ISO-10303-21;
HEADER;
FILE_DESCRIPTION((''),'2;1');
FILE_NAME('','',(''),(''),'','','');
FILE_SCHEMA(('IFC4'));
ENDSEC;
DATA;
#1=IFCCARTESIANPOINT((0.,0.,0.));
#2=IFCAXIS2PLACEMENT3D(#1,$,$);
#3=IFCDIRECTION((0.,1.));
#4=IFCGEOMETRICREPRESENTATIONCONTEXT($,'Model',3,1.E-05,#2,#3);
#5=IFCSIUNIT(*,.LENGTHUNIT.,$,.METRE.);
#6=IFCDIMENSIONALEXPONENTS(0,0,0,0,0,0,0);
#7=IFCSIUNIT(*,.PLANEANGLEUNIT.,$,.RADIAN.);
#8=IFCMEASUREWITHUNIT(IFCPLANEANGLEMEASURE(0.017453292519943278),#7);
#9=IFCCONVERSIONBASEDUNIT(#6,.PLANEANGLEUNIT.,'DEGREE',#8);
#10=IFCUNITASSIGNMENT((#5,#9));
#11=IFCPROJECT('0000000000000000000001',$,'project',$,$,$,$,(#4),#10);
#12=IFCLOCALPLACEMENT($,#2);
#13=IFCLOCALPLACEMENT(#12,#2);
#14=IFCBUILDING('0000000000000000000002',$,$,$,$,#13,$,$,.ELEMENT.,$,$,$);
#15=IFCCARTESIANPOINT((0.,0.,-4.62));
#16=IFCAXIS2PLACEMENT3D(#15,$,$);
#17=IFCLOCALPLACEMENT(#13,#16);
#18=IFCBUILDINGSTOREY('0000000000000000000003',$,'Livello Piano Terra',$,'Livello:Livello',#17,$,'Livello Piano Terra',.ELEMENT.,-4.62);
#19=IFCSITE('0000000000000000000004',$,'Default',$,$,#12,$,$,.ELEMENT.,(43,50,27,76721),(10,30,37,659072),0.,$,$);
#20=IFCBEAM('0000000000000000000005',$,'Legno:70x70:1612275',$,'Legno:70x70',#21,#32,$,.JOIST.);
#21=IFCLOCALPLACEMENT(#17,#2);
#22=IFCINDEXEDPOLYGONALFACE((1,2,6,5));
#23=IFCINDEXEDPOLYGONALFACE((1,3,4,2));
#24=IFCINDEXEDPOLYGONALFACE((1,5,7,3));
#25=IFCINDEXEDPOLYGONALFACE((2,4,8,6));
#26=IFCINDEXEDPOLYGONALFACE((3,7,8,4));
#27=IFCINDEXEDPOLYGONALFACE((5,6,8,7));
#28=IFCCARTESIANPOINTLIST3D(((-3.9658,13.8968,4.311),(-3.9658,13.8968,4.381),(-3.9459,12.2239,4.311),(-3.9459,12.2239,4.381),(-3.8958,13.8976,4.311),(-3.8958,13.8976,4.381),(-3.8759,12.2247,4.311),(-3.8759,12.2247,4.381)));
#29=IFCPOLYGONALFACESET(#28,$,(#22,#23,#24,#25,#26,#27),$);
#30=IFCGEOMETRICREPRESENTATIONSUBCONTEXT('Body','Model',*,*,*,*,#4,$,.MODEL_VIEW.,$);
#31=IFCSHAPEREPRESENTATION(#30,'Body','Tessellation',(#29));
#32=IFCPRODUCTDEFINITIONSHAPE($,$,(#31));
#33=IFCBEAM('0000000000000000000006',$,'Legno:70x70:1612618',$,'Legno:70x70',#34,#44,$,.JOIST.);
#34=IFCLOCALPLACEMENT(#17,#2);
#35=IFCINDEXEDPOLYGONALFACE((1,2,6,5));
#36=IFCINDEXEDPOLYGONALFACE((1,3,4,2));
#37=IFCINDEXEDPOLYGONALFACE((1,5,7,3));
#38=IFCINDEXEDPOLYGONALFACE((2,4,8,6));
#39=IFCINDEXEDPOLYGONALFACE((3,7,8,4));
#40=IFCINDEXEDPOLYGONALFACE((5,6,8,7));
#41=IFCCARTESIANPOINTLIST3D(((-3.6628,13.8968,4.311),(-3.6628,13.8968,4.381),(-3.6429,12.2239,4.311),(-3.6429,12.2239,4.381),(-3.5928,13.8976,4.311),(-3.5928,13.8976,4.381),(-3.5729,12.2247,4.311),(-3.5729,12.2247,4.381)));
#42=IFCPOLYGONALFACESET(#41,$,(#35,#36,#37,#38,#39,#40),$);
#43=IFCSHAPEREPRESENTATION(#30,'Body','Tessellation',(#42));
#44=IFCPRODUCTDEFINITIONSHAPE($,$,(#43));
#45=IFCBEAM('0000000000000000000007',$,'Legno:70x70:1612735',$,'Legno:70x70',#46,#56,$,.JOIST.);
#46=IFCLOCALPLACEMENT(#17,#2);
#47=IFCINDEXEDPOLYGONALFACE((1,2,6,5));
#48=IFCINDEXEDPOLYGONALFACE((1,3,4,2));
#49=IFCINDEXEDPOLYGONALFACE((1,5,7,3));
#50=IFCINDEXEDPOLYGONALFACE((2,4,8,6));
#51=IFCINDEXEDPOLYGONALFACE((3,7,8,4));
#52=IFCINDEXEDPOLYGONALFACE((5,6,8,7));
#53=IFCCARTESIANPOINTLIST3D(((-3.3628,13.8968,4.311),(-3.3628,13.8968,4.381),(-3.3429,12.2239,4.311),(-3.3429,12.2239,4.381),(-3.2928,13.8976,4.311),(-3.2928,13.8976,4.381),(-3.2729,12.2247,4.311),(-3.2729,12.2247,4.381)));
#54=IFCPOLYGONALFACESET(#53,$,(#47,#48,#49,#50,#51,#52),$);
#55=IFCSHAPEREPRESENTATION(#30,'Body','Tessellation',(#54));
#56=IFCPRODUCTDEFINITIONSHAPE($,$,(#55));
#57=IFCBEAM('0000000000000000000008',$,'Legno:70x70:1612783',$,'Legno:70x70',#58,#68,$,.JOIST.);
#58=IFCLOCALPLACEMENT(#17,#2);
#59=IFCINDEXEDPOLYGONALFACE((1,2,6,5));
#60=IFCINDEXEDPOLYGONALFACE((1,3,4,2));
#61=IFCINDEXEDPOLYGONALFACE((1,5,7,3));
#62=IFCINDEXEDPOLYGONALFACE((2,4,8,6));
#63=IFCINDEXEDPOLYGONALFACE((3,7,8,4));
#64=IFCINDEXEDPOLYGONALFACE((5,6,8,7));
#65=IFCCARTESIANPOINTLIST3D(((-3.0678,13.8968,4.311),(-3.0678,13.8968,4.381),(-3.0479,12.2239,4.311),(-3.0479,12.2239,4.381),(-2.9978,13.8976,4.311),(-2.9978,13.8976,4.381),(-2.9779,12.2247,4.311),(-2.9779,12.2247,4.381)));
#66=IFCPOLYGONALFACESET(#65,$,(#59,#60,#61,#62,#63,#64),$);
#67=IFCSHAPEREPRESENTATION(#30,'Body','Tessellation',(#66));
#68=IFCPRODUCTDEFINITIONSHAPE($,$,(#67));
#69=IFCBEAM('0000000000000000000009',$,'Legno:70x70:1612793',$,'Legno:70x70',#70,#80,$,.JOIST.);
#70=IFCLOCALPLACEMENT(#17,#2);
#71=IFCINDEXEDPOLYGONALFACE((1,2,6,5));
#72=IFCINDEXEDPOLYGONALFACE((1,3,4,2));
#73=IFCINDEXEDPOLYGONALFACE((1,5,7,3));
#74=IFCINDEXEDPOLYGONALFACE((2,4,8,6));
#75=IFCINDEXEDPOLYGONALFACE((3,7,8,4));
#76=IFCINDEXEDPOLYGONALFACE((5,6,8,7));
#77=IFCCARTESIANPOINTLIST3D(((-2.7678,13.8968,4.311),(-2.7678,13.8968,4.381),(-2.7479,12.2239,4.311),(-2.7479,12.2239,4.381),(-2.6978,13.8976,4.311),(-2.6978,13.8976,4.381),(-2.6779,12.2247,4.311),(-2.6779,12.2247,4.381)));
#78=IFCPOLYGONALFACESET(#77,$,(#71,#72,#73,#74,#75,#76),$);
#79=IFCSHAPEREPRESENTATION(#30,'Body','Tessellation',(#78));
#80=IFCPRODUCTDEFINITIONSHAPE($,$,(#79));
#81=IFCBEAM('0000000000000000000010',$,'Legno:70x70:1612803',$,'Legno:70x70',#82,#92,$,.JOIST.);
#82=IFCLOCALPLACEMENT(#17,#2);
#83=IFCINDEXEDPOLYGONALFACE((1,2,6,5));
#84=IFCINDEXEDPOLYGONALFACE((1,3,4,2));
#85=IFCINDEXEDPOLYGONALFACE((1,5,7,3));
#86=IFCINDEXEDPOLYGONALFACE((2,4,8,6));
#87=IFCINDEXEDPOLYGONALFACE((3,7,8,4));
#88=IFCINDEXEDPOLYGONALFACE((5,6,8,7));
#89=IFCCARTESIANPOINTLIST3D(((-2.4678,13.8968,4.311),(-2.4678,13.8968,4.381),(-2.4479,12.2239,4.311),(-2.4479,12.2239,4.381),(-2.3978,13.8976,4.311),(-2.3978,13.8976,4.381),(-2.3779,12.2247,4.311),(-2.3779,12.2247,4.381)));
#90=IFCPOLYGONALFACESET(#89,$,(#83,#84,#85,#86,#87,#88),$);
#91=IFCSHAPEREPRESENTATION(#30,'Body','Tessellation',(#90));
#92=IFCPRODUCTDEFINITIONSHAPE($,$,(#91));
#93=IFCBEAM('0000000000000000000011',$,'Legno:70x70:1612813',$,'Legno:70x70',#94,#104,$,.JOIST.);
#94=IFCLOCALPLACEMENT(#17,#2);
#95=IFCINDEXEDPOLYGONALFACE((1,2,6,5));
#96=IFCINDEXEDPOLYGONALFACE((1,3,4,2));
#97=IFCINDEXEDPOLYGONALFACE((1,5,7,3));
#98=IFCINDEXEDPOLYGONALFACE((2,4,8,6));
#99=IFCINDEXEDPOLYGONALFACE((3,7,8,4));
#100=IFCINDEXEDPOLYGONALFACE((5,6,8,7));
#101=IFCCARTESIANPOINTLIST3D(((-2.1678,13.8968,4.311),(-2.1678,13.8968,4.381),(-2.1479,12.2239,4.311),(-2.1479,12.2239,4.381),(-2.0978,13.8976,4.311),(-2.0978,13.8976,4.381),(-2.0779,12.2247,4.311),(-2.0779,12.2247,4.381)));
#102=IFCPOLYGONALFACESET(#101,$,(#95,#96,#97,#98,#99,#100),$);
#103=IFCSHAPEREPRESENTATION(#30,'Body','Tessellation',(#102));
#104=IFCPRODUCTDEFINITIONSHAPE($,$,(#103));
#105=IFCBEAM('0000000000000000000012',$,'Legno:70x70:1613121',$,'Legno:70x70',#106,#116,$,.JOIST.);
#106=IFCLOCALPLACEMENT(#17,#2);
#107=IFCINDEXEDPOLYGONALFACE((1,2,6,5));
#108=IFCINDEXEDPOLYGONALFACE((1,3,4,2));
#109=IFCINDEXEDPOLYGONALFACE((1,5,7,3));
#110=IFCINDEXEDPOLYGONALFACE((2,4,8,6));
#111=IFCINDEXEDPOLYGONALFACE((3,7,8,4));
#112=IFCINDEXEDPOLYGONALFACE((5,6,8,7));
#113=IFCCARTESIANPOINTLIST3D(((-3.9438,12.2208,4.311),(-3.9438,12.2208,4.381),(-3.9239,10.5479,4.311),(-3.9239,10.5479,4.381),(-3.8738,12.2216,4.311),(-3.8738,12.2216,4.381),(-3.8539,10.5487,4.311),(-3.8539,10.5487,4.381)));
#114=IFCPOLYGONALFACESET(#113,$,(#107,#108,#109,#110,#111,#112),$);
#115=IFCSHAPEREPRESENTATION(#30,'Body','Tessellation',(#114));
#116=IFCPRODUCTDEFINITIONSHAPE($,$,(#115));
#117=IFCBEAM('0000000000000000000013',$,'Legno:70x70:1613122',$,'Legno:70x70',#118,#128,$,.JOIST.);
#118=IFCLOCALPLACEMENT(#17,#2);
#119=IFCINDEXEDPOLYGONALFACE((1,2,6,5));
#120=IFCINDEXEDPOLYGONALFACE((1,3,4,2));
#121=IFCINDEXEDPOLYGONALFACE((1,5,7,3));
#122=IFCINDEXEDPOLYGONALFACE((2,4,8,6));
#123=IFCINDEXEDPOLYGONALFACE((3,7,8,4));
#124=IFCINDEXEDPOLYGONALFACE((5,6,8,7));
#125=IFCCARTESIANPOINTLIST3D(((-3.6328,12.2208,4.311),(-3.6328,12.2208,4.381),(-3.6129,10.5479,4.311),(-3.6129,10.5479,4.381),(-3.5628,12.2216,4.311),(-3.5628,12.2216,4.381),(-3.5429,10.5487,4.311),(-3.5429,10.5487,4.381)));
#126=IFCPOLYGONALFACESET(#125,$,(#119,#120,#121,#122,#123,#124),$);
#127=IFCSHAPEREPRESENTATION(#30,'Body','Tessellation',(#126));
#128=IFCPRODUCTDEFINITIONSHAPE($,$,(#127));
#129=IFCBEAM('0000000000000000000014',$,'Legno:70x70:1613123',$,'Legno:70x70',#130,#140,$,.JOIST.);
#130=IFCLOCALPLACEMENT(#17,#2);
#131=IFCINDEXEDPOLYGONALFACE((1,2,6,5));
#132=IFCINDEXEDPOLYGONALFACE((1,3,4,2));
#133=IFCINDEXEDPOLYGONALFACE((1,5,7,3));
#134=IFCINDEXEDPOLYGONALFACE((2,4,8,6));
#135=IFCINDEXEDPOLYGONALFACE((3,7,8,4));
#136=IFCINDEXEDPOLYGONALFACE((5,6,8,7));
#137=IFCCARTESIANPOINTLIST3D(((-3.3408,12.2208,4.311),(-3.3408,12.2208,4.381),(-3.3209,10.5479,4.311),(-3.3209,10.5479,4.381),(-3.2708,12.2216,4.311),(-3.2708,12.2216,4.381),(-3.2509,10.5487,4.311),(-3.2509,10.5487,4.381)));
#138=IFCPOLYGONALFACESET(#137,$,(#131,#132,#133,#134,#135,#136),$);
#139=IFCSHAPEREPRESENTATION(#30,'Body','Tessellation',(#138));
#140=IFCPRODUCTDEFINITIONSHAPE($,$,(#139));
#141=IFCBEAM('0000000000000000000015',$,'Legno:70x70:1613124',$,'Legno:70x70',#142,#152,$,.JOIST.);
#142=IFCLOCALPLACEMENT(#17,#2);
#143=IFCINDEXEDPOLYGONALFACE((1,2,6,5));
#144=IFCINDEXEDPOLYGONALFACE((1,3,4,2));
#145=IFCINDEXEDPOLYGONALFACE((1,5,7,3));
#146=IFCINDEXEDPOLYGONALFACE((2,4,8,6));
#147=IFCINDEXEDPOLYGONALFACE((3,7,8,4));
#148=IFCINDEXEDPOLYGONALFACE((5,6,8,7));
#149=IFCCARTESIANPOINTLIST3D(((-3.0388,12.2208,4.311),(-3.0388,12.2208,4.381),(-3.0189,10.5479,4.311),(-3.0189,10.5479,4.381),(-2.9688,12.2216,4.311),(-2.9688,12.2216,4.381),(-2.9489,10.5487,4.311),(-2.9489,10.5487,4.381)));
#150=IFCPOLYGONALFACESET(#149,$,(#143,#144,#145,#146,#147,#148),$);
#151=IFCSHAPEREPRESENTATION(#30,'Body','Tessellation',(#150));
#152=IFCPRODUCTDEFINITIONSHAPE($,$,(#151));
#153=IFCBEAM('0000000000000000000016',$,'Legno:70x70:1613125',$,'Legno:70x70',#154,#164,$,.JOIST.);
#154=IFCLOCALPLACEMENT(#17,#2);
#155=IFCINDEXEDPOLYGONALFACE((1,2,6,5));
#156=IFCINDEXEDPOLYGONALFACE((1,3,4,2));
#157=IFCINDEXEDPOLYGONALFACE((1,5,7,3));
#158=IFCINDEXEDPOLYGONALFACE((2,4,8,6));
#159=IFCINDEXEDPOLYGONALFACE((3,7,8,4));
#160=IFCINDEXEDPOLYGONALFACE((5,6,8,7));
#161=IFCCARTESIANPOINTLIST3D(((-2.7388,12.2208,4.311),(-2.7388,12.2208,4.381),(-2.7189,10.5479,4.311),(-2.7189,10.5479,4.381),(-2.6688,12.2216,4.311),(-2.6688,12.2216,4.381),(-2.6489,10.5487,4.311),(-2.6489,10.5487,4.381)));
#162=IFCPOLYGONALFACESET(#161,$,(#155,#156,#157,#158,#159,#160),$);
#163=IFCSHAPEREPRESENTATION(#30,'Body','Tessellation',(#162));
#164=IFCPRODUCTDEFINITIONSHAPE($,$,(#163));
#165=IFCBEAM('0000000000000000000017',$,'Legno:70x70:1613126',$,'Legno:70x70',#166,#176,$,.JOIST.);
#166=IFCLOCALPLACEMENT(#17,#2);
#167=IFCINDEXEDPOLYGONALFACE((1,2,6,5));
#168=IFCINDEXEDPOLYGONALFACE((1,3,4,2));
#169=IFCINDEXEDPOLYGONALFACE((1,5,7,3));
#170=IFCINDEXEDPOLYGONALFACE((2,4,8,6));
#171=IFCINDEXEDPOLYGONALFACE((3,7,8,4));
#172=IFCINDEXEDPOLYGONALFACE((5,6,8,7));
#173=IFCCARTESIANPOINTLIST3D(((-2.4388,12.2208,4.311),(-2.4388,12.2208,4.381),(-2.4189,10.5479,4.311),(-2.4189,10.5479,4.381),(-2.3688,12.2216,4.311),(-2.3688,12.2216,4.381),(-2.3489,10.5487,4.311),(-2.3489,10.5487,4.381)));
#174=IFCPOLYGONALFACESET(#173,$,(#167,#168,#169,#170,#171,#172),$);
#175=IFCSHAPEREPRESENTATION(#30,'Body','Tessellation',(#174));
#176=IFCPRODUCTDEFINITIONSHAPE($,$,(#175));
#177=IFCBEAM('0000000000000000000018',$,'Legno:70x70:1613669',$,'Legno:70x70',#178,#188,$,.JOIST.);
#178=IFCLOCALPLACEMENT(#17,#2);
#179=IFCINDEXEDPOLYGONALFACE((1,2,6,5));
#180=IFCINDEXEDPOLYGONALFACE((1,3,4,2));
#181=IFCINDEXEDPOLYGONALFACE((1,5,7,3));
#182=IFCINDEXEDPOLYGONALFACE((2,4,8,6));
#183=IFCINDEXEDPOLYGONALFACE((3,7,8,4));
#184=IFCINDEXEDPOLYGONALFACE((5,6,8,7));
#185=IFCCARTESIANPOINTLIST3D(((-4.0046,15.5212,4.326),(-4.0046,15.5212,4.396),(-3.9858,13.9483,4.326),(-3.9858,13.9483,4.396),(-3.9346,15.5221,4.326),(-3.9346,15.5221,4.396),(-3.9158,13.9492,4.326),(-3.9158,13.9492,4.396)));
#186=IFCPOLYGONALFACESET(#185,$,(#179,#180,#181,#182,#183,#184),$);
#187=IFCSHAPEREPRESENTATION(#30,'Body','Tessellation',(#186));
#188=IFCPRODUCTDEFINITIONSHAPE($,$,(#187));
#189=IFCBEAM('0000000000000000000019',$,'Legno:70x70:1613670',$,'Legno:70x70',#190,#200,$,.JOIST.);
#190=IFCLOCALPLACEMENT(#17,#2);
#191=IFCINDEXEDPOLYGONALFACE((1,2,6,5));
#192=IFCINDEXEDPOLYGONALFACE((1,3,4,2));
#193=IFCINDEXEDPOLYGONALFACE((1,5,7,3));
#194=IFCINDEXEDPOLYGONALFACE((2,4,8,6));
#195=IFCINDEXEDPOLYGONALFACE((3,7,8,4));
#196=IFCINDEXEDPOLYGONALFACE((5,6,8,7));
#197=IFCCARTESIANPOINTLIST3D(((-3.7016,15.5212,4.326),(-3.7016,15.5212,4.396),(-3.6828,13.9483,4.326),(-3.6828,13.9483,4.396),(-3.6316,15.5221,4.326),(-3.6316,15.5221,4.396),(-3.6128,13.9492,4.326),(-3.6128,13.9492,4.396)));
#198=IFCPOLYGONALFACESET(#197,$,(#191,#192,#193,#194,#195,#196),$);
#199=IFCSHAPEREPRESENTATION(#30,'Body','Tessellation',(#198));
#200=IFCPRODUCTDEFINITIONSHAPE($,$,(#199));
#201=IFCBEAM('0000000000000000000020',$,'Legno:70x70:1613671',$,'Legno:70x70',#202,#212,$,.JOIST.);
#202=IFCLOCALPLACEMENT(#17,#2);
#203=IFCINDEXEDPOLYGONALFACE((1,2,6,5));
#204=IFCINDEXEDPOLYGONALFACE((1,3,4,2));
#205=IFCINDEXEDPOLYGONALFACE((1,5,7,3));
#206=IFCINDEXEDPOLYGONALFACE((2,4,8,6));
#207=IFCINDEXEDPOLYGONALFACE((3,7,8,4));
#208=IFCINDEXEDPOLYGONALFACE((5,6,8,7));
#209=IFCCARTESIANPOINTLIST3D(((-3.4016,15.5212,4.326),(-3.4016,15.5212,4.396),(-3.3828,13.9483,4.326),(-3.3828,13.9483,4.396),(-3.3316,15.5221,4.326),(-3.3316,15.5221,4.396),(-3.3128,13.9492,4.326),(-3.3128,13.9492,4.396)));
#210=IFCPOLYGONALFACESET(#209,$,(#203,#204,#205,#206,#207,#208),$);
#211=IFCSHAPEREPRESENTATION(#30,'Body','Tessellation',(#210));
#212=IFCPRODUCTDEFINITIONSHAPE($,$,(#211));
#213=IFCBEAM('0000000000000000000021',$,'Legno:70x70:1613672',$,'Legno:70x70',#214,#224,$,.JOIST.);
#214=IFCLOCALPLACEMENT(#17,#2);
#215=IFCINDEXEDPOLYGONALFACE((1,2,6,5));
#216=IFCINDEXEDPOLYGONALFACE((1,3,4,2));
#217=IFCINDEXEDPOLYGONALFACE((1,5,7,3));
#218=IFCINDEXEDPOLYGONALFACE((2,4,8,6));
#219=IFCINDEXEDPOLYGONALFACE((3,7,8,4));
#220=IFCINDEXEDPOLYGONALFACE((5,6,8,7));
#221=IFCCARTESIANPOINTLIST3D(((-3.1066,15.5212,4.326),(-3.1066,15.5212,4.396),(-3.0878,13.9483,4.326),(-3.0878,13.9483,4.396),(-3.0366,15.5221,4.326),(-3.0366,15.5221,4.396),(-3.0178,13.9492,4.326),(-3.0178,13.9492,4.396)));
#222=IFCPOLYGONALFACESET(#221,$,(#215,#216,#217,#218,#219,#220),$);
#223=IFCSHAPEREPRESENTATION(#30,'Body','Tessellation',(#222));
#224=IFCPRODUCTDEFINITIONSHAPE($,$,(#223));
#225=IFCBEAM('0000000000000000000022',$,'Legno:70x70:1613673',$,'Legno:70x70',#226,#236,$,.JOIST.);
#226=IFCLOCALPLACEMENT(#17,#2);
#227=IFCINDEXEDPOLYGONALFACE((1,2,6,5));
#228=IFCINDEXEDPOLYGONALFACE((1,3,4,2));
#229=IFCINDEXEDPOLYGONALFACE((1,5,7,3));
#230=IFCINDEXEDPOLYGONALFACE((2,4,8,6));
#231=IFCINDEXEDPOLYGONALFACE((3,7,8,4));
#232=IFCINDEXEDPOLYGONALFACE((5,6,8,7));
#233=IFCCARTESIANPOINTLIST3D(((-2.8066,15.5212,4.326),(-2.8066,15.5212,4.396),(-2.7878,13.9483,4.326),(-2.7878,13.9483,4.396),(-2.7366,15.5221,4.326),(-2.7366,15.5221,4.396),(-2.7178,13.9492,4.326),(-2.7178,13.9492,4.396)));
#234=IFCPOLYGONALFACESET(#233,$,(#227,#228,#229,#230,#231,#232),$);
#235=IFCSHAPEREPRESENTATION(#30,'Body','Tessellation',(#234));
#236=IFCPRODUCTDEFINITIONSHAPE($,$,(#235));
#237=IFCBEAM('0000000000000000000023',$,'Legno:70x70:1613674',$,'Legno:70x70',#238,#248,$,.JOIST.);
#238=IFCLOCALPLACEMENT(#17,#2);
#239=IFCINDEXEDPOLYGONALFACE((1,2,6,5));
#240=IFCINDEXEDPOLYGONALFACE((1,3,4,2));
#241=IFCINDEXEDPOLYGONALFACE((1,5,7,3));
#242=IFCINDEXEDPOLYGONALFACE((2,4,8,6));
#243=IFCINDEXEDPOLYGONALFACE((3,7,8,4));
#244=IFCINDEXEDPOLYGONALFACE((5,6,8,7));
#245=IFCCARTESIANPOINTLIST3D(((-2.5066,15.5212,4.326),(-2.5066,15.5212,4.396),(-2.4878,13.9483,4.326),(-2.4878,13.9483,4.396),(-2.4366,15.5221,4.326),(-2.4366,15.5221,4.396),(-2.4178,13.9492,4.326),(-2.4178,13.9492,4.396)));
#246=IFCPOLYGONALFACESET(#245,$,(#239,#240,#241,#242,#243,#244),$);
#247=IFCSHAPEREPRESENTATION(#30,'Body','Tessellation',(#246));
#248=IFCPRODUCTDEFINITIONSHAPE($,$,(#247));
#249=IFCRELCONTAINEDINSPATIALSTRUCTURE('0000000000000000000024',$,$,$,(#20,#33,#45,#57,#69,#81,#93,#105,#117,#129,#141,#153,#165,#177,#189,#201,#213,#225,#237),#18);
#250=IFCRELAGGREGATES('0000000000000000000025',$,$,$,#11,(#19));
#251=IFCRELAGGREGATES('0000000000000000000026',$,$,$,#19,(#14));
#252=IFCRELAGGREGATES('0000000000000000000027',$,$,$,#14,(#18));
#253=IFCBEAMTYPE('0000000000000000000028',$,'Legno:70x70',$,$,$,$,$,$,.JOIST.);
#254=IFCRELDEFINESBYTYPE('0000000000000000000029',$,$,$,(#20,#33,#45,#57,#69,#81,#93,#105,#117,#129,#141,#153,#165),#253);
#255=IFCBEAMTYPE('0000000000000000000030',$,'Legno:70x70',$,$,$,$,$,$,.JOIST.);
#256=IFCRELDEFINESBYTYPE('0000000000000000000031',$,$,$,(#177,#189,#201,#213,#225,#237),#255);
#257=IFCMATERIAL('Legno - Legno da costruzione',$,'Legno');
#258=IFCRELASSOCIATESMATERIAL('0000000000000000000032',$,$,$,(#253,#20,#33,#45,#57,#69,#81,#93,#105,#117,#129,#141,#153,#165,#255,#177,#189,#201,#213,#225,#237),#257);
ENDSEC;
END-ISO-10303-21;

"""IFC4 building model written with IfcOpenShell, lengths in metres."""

from ifc_helpers import new_model, entity, si_unit, converted_unit, direction, frame, origin, place, context, subcontext, project, spatial, indexed_curve, outline, extrude, source, transform, mapped, material, type_object, type_shapes, element, save


model = new_model("IFC4")

# Units and contexts
model_context = context("Model", 3, precision=1e-05, world=origin(), true_north=direction((0.0, 1.0)))
body_context = subcontext(model_context, "Body", "Model", "MODEL_VIEW")
ifc_project = project(units=[si_unit("LENGTHUNIT", "METRE"), converted_unit("PLANEANGLEUNIT", "DEGREE", entity("IfcPlaneAngleMeasure", 0.017453292519943278), si_unit("PLANEANGLEUNIT", "RADIAN"), dimensions=[0, 0, 0, 0, 0, 0, 0])], contexts=[model_context])

# Site, building, storey
site_placement = place(None, origin())
site = spatial("IfcSite", under=ifc_project, at=site_placement, Name="Default", CompositionType="ELEMENT", RefLatitude=(43, 50, 27, 76721), RefLongitude=(10, 30, 37, 659072), RefElevation=0.0)
building_placement = place(site_placement, origin())
building = spatial("IfcBuilding", under=site, at=building_placement, CompositionType="ELEMENT")
storey_placement = place(building_placement, frame((0.0, 0.0, -4.62)))
storey = spatial("IfcBuildingStorey", under=building, at=storey_placement, Name="Livello Piano Terra", ObjectType="Livello:Livello", LongName="Livello Piano Terra", CompositionType="ELEMENT", Elevation=-4.62)

# Beams
ifc_material = material(Name="Legno - Legno da costruzione", Category="Legno")
beam_type_1 = type_object("IfcBeamType", Name="Legno:70x70", PredefinedType="JOIST", material=ifc_material)
shared_shape_1 = source(origin(), body_context, "Body", "SweptSolid", [
    extrude(outline(indexed_curve([(-0.8365, -0.035), (0.8365, -0.035), (0.8365, 0.035), (-0.8365, 0.035), (-0.8365, -0.035)], self_intersect=False)), frame((0.0, 0.0, -0.035), z_axis=(0.0, 0.0, 1.0), x_axis=(-1.0, 0.0, 0.0)), (0.0, 0.0, 1.0), 0.07),
])
type_shapes(beam_type_1, [shared_shape_1])
for number, where, z_axis, x_axis, name in (
    (1, (-3.9208, 13.0608, 4.346), (0.0, 0.0, 1.0), (0.011914, -0.999929, 0.0), "Legno:70x70:1612275"),
    (2, (-3.6178, 13.0608, 4.346), (0.0, 0.0, 1.0), (0.011914, -0.999929, 0.0), "Legno:70x70:1612618"),
    (3, (-3.3178, 13.0608, 4.346), (0.0, 0.0, 1.0), (0.011914, -0.999929, 0.0), "Legno:70x70:1612735"),
    (4, (-3.0228, 13.0608, 4.346), (0.0, 0.0, 1.0), (0.011914, -0.999929, 0.0), "Legno:70x70:1612783"),
    (5, (-2.7228, 13.0608, 4.346), (0.0, 0.0, 1.0), (0.011914, -0.999929, 0.0), "Legno:70x70:1612793"),
    (6, (-2.4228, 13.0608, 4.346), (0.0, 0.0, 1.0), (0.011914, -0.999929, 0.0), "Legno:70x70:1612803"),
    (7, (-2.1228, 13.0608, 4.346), (0.0, 0.0, 1.0), (0.011914, -0.999929, 0.0), "Legno:70x70:1612813"),
    (8, (-3.8988, 11.3848, 4.346), (0.0, 0.0, 1.0), (0.011914, -0.999929, 0.0), "Legno:70x70:1613121"),
    (9, (-3.5878, 11.3848, 4.346), (0.0, 0.0, 1.0), (0.011914, -0.999929, 0.0), "Legno:70x70:1613122"),
    (10, (-3.2958, 11.3848, 4.346), (0.0, 0.0, 1.0), (0.011914, -0.999929, 0.0), "Legno:70x70:1613123"),
    (11, (-2.9938, 11.3848, 4.346), (0.0, 0.0, 1.0), (0.011914, -0.999929, 0.0), "Legno:70x70:1613124"),
    (12, (-2.6938, 11.3848, 4.346), (0.0, 0.0, 1.0), (0.011914, -0.999929, 0.0), "Legno:70x70:1613125"),
    (13, (-2.3938, 11.3848, 4.346), (0.0, 0.0, 1.0), (0.011914, -0.999929, 0.0), "Legno:70x70:1613126"),
):
    element("IfcBeam", number, at=place(storey_placement, frame(where, z_axis=z_axis, x_axis=x_axis)), inside=storey, type_object=beam_type_1, material=ifc_material, Name=name, ObjectType="Legno:70x70", PredefinedType="JOIST", context=body_context, shape_type="MappedRepresentation", body=[
        mapped(shared_shape_1, transform((0.0, 0.0, 0.0), scale=1.0)),
    ])
beam_type_2 = type_object("IfcBeamType", Name="Legno:70x70", PredefinedType="JOIST", material=ifc_material)
shared_shape_2 = source(origin(), body_context, "Body", "SweptSolid", [
    extrude(outline(indexed_curve([(-0.7865, -0.035), (0.7865, -0.035), (0.7865, 0.035), (-0.7865, 0.035), (-0.7865, -0.035)], self_intersect=False)), frame((0.0, 0.0, -0.035), z_axis=(0.0, 0.0, 1.0), x_axis=(-1.0, 0.0, 0.0)), (0.0, 0.0, 1.0), 0.07),
])
type_shapes(beam_type_2, [shared_shape_2])
for number, where, z_axis, x_axis, name in (
    (14, (-3.9602, 14.7352, 4.361), (0.0, 0.0, 1.0), (0.011914, -0.999929, 0.0), "Legno:70x70:1613669"),
    (15, (-3.6572, 14.7352, 4.361), (0.0, 0.0, 1.0), (0.011914, -0.999929, 0.0), "Legno:70x70:1613670"),
    (16, (-3.3572, 14.7352, 4.361), (0.0, 0.0, 1.0), (0.011914, -0.999929, 0.0), "Legno:70x70:1613671"),
    (17, (-3.0622, 14.7352, 4.361), (0.0, 0.0, 1.0), (0.011914, -0.999929, 0.0), "Legno:70x70:1613672"),
    (18, (-2.7622, 14.7352, 4.361), (0.0, 0.0, 1.0), (0.011914, -0.999929, 0.0), "Legno:70x70:1613673"),
    (19, (-2.4622, 14.7352, 4.361), (0.0, 0.0, 1.0), (0.011914, -0.999929, 0.0), "Legno:70x70:1613674"),
):
    element("IfcBeam", number, at=place(storey_placement, frame(where, z_axis=z_axis, x_axis=x_axis)), inside=storey, type_object=beam_type_2, material=ifc_material, Name=name, ObjectType="Legno:70x70", PredefinedType="JOIST", context=body_context, shape_type="MappedRepresentation", body=[
        mapped(shared_shape_2, transform((0.0, 0.0, 0.0), scale=1.0)),
    ])

save(model, "model.ifc")
